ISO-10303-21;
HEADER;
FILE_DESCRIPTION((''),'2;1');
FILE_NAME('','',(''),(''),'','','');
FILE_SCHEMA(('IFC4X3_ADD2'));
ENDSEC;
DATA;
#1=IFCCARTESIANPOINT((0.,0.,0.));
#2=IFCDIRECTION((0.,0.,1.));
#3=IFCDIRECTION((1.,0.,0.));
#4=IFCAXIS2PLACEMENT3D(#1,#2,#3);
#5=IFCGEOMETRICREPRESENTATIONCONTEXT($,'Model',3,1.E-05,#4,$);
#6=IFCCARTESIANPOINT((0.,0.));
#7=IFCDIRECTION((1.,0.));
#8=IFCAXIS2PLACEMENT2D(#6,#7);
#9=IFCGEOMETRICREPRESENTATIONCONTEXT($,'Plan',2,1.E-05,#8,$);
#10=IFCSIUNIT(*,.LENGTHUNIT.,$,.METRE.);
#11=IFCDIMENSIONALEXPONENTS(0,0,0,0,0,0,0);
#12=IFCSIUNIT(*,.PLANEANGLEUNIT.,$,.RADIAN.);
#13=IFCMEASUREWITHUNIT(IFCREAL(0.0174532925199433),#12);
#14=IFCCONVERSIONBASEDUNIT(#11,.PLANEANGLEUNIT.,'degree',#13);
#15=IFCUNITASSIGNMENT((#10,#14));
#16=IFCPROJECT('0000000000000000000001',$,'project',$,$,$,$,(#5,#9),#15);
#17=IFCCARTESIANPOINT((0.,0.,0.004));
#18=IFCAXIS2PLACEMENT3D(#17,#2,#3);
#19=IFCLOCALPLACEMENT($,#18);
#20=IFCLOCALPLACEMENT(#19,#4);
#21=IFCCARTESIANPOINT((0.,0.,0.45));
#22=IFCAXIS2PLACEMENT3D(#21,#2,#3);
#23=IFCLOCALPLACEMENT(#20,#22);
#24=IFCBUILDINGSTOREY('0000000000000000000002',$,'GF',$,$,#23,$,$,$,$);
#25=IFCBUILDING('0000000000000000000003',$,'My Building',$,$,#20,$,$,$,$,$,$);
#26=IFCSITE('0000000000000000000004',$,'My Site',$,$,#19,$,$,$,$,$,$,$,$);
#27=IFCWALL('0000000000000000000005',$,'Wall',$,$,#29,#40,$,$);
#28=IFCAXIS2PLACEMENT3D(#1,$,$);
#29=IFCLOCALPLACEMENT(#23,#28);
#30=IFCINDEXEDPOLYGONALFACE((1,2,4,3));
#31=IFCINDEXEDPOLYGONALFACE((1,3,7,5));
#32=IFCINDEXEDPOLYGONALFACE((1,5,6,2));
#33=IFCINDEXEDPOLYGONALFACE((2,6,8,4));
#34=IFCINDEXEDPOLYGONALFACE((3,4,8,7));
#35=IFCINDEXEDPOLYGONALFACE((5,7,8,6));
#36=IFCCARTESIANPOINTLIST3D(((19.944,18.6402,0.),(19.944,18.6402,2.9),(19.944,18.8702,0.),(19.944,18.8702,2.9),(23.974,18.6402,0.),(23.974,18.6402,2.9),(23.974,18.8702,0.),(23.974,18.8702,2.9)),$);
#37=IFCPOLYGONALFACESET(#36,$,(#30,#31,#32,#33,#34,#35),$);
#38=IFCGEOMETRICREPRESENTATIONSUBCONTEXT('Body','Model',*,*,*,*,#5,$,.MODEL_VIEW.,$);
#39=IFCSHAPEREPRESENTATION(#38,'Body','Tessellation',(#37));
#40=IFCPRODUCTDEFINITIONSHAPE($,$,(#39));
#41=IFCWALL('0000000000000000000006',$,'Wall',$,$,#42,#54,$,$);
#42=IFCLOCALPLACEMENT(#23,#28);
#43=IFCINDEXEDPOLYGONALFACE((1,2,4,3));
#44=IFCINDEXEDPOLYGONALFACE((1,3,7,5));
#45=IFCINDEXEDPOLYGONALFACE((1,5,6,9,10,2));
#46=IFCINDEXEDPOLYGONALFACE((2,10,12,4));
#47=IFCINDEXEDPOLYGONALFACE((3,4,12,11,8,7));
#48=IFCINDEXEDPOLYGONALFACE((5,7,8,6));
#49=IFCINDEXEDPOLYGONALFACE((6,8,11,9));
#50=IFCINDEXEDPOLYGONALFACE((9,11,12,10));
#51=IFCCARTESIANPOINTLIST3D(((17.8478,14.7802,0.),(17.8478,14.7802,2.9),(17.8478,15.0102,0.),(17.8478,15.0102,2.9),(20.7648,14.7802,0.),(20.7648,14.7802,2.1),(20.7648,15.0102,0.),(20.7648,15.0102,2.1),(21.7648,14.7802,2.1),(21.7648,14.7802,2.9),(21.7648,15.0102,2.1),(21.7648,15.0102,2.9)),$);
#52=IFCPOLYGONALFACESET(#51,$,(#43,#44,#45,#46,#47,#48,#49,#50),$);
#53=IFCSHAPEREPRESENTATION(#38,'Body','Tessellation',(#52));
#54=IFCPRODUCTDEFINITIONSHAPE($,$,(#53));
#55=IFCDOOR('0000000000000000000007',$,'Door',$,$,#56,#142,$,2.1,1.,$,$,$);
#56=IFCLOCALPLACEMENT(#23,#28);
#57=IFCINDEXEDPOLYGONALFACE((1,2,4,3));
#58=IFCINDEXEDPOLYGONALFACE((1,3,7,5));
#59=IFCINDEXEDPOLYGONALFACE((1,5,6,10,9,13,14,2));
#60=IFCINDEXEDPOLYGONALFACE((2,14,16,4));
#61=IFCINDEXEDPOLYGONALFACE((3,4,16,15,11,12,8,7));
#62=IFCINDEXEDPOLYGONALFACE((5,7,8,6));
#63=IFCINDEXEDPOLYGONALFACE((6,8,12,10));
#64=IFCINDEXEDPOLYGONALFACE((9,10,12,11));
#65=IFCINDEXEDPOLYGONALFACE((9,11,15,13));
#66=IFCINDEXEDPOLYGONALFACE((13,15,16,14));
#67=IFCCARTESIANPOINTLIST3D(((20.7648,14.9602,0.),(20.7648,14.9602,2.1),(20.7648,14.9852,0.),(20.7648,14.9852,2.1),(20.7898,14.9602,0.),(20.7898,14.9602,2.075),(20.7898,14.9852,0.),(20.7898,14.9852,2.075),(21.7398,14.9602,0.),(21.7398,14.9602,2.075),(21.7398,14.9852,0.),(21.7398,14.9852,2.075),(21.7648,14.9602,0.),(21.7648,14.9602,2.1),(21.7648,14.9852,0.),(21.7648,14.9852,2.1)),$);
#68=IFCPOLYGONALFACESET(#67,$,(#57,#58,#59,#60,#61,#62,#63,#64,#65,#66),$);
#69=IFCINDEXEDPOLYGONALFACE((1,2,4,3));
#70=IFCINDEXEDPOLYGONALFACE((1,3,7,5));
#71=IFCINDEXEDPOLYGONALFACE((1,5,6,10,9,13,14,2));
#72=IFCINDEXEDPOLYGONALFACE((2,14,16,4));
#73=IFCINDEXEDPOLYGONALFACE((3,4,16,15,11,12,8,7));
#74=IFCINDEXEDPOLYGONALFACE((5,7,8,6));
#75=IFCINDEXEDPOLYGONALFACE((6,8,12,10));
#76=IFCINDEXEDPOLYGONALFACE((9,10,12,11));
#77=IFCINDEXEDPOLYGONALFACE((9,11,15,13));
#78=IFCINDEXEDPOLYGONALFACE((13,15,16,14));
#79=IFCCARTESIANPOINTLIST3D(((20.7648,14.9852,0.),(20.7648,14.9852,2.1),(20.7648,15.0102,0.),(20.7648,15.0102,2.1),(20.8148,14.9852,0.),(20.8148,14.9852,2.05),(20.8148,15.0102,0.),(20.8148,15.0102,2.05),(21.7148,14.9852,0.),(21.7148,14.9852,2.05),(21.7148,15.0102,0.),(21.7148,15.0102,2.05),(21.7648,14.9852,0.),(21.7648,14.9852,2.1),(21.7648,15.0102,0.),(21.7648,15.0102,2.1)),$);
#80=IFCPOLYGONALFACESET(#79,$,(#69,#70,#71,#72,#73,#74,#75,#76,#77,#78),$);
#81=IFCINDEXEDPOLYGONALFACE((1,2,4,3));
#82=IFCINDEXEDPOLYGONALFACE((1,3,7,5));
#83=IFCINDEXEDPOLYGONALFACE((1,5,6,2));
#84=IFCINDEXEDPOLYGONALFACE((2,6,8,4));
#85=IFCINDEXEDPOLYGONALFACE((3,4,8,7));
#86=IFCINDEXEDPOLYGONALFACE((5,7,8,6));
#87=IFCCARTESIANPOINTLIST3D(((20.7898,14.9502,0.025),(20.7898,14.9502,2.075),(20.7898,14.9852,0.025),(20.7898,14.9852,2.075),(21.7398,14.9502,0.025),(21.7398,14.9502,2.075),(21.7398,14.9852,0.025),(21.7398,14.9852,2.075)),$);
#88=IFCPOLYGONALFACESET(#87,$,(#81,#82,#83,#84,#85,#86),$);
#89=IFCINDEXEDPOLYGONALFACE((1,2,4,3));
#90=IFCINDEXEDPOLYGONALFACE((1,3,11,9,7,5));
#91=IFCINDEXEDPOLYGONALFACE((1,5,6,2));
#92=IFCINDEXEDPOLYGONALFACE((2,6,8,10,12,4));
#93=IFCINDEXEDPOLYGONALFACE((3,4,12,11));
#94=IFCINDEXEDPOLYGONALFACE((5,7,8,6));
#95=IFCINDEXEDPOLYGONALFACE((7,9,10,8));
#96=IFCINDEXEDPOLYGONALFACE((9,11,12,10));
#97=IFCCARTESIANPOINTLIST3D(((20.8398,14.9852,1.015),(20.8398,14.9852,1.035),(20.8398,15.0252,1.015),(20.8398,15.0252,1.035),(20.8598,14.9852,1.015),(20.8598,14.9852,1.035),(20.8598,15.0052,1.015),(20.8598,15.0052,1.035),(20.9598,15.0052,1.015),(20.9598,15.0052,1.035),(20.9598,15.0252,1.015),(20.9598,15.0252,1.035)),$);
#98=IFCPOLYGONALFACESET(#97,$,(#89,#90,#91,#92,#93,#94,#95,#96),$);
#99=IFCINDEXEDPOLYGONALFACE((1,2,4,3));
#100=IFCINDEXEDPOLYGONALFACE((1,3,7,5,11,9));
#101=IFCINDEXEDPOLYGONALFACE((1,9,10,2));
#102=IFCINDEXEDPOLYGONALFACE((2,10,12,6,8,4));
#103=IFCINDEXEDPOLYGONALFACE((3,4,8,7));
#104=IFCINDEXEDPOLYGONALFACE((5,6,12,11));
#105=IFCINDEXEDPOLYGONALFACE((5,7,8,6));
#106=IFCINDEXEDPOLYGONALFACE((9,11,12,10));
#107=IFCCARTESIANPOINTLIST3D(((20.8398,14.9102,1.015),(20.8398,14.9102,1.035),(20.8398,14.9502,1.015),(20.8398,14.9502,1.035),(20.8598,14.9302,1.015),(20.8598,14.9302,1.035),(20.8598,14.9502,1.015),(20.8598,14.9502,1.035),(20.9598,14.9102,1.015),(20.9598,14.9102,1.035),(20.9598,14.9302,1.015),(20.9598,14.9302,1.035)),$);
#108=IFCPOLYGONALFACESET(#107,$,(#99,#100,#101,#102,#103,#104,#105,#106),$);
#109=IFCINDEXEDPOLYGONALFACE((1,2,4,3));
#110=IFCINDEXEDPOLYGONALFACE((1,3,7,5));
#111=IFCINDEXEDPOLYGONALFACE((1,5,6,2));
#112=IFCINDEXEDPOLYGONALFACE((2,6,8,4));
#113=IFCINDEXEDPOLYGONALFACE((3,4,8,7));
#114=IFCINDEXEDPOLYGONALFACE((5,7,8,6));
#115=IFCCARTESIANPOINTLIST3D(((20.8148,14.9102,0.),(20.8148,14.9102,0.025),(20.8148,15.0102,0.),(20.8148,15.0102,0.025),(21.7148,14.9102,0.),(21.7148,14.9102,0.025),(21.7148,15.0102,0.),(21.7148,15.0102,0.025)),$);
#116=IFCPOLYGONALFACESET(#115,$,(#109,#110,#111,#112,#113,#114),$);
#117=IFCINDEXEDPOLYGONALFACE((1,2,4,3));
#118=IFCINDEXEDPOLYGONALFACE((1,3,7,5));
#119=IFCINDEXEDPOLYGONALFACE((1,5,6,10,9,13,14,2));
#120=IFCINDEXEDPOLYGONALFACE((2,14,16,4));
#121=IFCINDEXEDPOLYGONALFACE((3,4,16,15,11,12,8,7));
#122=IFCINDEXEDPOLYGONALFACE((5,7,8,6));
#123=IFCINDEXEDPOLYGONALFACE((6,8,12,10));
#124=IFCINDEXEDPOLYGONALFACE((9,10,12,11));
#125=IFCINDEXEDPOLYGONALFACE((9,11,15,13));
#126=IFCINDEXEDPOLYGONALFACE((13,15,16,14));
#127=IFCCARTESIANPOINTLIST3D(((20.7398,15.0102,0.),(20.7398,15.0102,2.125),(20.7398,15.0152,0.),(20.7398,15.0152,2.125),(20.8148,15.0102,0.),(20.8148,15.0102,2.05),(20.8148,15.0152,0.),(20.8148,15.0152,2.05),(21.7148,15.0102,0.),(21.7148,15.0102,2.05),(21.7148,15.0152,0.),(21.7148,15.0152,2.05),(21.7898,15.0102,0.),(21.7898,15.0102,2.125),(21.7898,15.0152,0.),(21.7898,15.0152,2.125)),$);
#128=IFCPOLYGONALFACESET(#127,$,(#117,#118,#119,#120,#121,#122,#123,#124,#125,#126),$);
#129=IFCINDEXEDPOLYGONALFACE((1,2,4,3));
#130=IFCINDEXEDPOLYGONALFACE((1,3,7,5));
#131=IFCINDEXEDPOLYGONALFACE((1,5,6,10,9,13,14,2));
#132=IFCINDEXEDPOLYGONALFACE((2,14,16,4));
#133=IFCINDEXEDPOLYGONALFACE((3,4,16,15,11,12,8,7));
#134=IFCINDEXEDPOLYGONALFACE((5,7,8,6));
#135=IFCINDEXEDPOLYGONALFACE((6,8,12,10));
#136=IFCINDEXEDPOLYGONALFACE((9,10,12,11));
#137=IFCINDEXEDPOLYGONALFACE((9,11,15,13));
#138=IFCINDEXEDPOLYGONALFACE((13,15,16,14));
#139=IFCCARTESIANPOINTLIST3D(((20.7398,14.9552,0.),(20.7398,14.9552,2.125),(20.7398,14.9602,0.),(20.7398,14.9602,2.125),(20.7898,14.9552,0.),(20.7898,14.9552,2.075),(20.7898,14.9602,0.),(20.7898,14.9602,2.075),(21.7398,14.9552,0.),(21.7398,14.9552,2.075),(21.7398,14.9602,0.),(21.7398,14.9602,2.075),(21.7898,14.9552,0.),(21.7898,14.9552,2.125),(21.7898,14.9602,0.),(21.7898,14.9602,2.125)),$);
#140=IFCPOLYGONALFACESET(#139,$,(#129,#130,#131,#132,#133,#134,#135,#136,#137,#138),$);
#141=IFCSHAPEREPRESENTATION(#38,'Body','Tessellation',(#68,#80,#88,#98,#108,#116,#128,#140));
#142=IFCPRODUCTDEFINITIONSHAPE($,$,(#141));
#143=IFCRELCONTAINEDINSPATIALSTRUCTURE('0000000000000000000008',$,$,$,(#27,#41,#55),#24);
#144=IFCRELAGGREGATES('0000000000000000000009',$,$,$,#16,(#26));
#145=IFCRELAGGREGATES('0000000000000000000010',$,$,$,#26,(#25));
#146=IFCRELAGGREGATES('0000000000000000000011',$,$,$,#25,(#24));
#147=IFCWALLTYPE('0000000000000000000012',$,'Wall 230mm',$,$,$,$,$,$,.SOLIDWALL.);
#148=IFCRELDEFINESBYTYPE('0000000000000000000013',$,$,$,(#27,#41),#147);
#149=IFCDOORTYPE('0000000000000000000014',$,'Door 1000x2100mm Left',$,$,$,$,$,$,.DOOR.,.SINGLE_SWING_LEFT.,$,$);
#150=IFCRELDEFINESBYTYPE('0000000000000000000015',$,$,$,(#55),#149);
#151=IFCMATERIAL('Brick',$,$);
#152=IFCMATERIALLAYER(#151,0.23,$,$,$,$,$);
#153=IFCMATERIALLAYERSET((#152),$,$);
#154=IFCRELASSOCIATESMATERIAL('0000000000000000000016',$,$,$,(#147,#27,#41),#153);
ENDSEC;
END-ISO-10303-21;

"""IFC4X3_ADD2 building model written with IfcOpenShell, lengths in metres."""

from ifc_helpers import new_model, entity, si_unit, converted_unit, frame, origin_with_axes, origin_2d_with_axis, place, context, subcontext, project, spatial, line, indexed_curve, outline, extrude, shape, source, transform, mapped, material, layer, layer_set, layer_usage, type_object, type_shapes, element, fill, save


model = new_model("IFC4X3_ADD2")

# Units and contexts
model_context = context("Model", 3, precision=1e-05, world=origin_with_axes())
plan_context = context("Plan", 2, precision=1e-05, world=origin_2d_with_axis())
body_context_1 = subcontext(model_context, "Body", "Model", "MODEL_VIEW")
body_context_2 = subcontext(plan_context, "Body", "Plan", "PLAN_VIEW")
ifc_project = project(units=[si_unit("LENGTHUNIT", "METRE"), converted_unit("PLANEANGLEUNIT", "degree", entity("IfcReal", 0.0174532925199433), si_unit("PLANEANGLEUNIT", "RADIAN"), dimensions=[0, 0, 0, 0, 0, 0, 0])], contexts=[model_context, plan_context])

# Site, building, storey
site_placement = place(None, frame((0.0, 0.0, 0.004), z_axis=(0.0, 0.0, 1.0), x_axis=(1.0, 0.0, 0.0)))
site = spatial("IfcSite", under=ifc_project, at=site_placement, Name="My Site")
building_placement = place(site_placement, origin_with_axes())
building = spatial("IfcBuilding", under=site, at=building_placement, Name="My Building")
storey_placement = place(building_placement, frame((0.0, 0.0, 0.45), z_axis=(0.0, 0.0, 1.0), x_axis=(1.0, 0.0, 0.0)))
storey = spatial("IfcBuildingStorey", under=building, at=storey_placement, Name="GF")

# Wall
ifc_material_1 = material(Name="Brick")
ifc_layer_1 = layer(ifc_material_1, 0.23)
ifc_layer_set_1 = layer_set([ifc_layer_1])
wall_type = type_object("IfcWallType", Name="Wall 230mm", PredefinedType="SOLIDWALL", material=ifc_layer_set_1)
ifc_layer_usage_1 = layer_usage(ifc_layer_set_1, "AXIS2", "POSITIVE", 0.0)
wall_1_placement = place(storey_placement, frame((23.974, 18.8702, 0.0), z_axis=(0.0, 0.0, 1.0), x_axis=(-1.0, 0.0, 0.0)))
element("IfcWall", 1, at=wall_1_placement, inside=storey, type_object=wall_type, material=ifc_layer_usage_1, Name="Wall", context=body_context_1, shape_type="SweptSolid", body=[
    extrude(outline(indexed_curve([(0.0, 0.0), (0.0, 0.23), (4.03, 0.23), (4.03, 0.0), (0.0, 0.0)], self_intersect=False)), origin_with_axes(), (0.0, 0.0, 1.0), 2.9),
])

# Wall, opening, door
ifc_layer_usage_2 = layer_usage(ifc_layer_set_1, "AXIS2", "POSITIVE", 0.0)
wall_2_placement = place(storey_placement, frame((21.7648, 15.0102, 0.0), z_axis=(0.0, 0.0, 1.0), x_axis=(-1.0, 0.0, 0.0)))
wall_2 = element("IfcWall", 2, at=wall_2_placement, inside=storey, type_object=wall_type, material=ifc_layer_usage_2, Name="Wall", context=body_context_1, shape_type="SweptSolid", body=[
    extrude(outline(indexed_curve([(0.0, 0.0), (0.0, 0.23), (3.917, 0.23), (3.917, 0.0), (0.0, 0.0)], self_intersect=False)), origin_with_axes(), (0.0, 0.0, 1.0), 2.9),
])
shared_shape_1 = source(origin_with_axes(), body_context_1, "Body", "SweptSolid", [
    extrude(outline(indexed_curve([(0.0, 0.0), (1.0, 0.0), (1.0, 2.1), (0.0, 2.1)], segments=[line(1, 2, 3, 4, 1)])), frame((0.0, -0.6, 0.0), z_axis=(0.0, -1.0, 0.0), x_axis=(1.0, 0.0, 0.0)), (0.0, 0.0, -1.0), 1.2),
])
opening_1_placement = place(wall_2_placement, frame((0.0, 0.0, 0.0), z_axis=(0.0, 0.0, 1.0), x_axis=(1.0, 0.0, 0.0)))
opening_1 = element("IfcOpeningElement", 3, at=opening_1_placement, cuts=wall_2, PredefinedType="OPENING", context=body_context_1, shape_type="MappedRepresentation", body=[
    mapped(shared_shape_1, transform((0.0, 0.0, 0.0), x_axis=(1.0, 0.0, 0.0), y_axis=(0.0, 1.0, 0.0), z_axis=(0.0, 0.0, 1.0), scale=1.0)),
])
door_type_1 = type_object("IfcDoorType", Name="Door 1000x2100mm Left", OperationType="SINGLE_SWING_LEFT", PredefinedType="DOOR")
shared_shape_2 = source(origin_with_axes(), body_context_1, "Body", "SweptSolid", [
    extrude(outline(indexed_curve([(0.0, 0.0), (0.0, 2.1), (1.0, 2.1), (1.0, 0.0), (0.975, 0.0), (0.975, 2.075), (0.025, 2.075), (0.025, 0.0)], segments=[line(1, 2, 3, 4, 5, 6, 7, 8, 1)])), frame((0.0, 0.025, 0.0), z_axis=(0.0, -1.0, 0.0), x_axis=(1.0, 0.0, 0.0)), (0.0, 0.0, -1.0), 0.025),
    extrude(outline(indexed_curve([(0.0, 0.0), (0.0, 2.1), (1.0, 2.1), (1.0, 0.0), (0.95, 0.0), (0.95, 2.05), (0.05, 2.05), (0.05, 0.0)], segments=[line(1, 2, 3, 4, 5, 6, 7, 8, 1)])), frame((0.0, 0.0, 0.0), z_axis=(0.0, -1.0, 0.0), x_axis=(1.0, 0.0, 0.0)), (0.0, 0.0, -1.0), 0.025),
    extrude(outline(indexed_curve([(0.0, 0.0), (0.95, 0.0), (0.95, 0.035), (0.0, 0.035)], segments=[line(1, 2, 3, 4, 1)])), frame((0.025, 0.025, 0.025), z_axis=(0.0, 0.0, 1.0), x_axis=(1.0, 0.0, 0.0)), (0.0, 0.0, 1.0), 2.05),
    extrude(outline(indexed_curve([(0.0, 0.0), (0.0, -0.04), (-0.12, -0.04), (-0.12, -0.02), (-0.02, -0.02), (-0.02, 0.0)], segments=[line(1, 2, 3, 4, 5, 6, 1)])), frame((0.925, 0.025, 1.015), z_axis=(0.0, 0.0, 1.0), x_axis=(1.0, 0.0, 0.0)), (0.0, 0.0, 1.0), 0.02),
    extrude(outline(indexed_curve([(0.0, 0.0), (0.0, 0.04), (-0.12, 0.04), (-0.12, 0.02), (-0.02, 0.02), (-0.02, 0.0)], segments=[line(1, 2, 3, 4, 5, 6, 1)])), frame((0.925, 0.06, 1.015), z_axis=(0.0, 0.0, 1.0), x_axis=(1.0, 0.0, 0.0)), (0.0, 0.0, 1.0), 0.02),
    extrude(outline(indexed_curve([(0.0, 0.0), (0.9, 0.0), (0.9, 0.1), (0.0, 0.1)], segments=[line(1, 2, 3, 4, 1)])), frame((0.05, 0.0, 0.0), z_axis=(0.0, 0.0, 1.0), x_axis=(1.0, 0.0, 0.0)), (0.0, 0.0, 1.0), 0.025),
    extrude(outline(indexed_curve([(0.0, 0.0), (0.0, 2.125), (1.05, 2.125), (1.05, 0.0), (0.975, 0.0), (0.975, 2.05), (0.075, 2.05), (0.075, 0.0)], segments=[line(1, 2, 3, 4, 5, 6, 7, 8, 1)])), frame((-0.025, -0.005, 0.0), z_axis=(0.0, -1.0, 0.0), x_axis=(1.0, 0.0, 0.0)), (0.0, 0.0, -1.0), 0.005),
    extrude(outline(indexed_curve([(0.0, 0.0), (0.0, 2.125), (1.05, 2.125), (1.05, 0.0), (1.0, 0.0), (1.0, 2.075), (0.05, 2.075), (0.05, 0.0)], segments=[line(1, 2, 3, 4, 5, 6, 7, 8, 1)])), frame((-0.025, 0.05, 0.0), z_axis=(0.0, -1.0, 0.0), x_axis=(1.0, 0.0, 0.0)), (0.0, 0.0, -1.0), 0.005),
])
shared_shape_3 = source(origin_with_axes(), body_context_2, "Body", "Curve2D", [
    entity("IfcIndexedPolyCurve", entity("IfcCartesianPointList2D", [[0.0, 0.0], [0.0, 0.05], [0.025, 0.05], [0.025, 0.025], [0.05, 0.025], [0.05, 0.0]]), [entity("IfcLineIndex", [1, 2, 3, 4, 5, 6, 1])]),
    entity("IfcIndexedPolyCurve", entity("IfcCartesianPointList2D", [[1.0, 0.0], [1.0, 0.05], [0.975, 0.05], [0.975, 0.025], [0.95, 0.025], [0.95, 0.0]]), [entity("IfcLineIndex", [1, 2, 3, 4, 5, 6, 1])]),
    entity("IfcTrimmedCurve", entity("IfcEllipse", entity("IfcAxis2Placement2D", entity("IfcCartesianPoint", [0.06, 0.05]), entity("IfcDirection", [1.0, 0.0])), 0.915, 0.95), [entity("IfcCartesianPoint", [0.975, 0.05])], [entity("IfcCartesianPoint", [0.06, 1.0])], True, "CARTESIAN"),
    entity("IfcIndexedPolyCurve", entity("IfcCartesianPointList2D", [[0.025, 0.05], [0.06, 0.05], [0.06, 1.0], [0.025, 1.0]]), [entity("IfcLineIndex", [1, 2, 3, 4, 1])]),
])
type_shapes(door_type_1, [shared_shape_2, shared_shape_3])
door_1_placement = place(opening_1_placement, origin_with_axes())
door_1 = element("IfcDoor", 4, at=door_1_placement, inside=storey, type_object=door_type_1, Name="Door", OverallHeight=2.1, OverallWidth=1.0, shapes=[
    shape(body_context_1, "Body", "MappedRepresentation", [mapped(shared_shape_2, transform((0.0, 0.0, 0.0), x_axis=(1.0, 0.0, 0.0), y_axis=(0.0, 1.0, 0.0), z_axis=(0.0, 0.0, 1.0), scale=1.0))]),
    shape(body_context_2, "Body", "MappedRepresentation", [mapped(shared_shape_3, transform((0.0, 0.0, 0.0), x_axis=(1.0, 0.0, 0.0), y_axis=(0.0, 1.0, 0.0), z_axis=(0.0, 0.0, 1.0), scale=1.0))]),
])
fill(opening_1, door_1)

save(model, "model.ifc")
